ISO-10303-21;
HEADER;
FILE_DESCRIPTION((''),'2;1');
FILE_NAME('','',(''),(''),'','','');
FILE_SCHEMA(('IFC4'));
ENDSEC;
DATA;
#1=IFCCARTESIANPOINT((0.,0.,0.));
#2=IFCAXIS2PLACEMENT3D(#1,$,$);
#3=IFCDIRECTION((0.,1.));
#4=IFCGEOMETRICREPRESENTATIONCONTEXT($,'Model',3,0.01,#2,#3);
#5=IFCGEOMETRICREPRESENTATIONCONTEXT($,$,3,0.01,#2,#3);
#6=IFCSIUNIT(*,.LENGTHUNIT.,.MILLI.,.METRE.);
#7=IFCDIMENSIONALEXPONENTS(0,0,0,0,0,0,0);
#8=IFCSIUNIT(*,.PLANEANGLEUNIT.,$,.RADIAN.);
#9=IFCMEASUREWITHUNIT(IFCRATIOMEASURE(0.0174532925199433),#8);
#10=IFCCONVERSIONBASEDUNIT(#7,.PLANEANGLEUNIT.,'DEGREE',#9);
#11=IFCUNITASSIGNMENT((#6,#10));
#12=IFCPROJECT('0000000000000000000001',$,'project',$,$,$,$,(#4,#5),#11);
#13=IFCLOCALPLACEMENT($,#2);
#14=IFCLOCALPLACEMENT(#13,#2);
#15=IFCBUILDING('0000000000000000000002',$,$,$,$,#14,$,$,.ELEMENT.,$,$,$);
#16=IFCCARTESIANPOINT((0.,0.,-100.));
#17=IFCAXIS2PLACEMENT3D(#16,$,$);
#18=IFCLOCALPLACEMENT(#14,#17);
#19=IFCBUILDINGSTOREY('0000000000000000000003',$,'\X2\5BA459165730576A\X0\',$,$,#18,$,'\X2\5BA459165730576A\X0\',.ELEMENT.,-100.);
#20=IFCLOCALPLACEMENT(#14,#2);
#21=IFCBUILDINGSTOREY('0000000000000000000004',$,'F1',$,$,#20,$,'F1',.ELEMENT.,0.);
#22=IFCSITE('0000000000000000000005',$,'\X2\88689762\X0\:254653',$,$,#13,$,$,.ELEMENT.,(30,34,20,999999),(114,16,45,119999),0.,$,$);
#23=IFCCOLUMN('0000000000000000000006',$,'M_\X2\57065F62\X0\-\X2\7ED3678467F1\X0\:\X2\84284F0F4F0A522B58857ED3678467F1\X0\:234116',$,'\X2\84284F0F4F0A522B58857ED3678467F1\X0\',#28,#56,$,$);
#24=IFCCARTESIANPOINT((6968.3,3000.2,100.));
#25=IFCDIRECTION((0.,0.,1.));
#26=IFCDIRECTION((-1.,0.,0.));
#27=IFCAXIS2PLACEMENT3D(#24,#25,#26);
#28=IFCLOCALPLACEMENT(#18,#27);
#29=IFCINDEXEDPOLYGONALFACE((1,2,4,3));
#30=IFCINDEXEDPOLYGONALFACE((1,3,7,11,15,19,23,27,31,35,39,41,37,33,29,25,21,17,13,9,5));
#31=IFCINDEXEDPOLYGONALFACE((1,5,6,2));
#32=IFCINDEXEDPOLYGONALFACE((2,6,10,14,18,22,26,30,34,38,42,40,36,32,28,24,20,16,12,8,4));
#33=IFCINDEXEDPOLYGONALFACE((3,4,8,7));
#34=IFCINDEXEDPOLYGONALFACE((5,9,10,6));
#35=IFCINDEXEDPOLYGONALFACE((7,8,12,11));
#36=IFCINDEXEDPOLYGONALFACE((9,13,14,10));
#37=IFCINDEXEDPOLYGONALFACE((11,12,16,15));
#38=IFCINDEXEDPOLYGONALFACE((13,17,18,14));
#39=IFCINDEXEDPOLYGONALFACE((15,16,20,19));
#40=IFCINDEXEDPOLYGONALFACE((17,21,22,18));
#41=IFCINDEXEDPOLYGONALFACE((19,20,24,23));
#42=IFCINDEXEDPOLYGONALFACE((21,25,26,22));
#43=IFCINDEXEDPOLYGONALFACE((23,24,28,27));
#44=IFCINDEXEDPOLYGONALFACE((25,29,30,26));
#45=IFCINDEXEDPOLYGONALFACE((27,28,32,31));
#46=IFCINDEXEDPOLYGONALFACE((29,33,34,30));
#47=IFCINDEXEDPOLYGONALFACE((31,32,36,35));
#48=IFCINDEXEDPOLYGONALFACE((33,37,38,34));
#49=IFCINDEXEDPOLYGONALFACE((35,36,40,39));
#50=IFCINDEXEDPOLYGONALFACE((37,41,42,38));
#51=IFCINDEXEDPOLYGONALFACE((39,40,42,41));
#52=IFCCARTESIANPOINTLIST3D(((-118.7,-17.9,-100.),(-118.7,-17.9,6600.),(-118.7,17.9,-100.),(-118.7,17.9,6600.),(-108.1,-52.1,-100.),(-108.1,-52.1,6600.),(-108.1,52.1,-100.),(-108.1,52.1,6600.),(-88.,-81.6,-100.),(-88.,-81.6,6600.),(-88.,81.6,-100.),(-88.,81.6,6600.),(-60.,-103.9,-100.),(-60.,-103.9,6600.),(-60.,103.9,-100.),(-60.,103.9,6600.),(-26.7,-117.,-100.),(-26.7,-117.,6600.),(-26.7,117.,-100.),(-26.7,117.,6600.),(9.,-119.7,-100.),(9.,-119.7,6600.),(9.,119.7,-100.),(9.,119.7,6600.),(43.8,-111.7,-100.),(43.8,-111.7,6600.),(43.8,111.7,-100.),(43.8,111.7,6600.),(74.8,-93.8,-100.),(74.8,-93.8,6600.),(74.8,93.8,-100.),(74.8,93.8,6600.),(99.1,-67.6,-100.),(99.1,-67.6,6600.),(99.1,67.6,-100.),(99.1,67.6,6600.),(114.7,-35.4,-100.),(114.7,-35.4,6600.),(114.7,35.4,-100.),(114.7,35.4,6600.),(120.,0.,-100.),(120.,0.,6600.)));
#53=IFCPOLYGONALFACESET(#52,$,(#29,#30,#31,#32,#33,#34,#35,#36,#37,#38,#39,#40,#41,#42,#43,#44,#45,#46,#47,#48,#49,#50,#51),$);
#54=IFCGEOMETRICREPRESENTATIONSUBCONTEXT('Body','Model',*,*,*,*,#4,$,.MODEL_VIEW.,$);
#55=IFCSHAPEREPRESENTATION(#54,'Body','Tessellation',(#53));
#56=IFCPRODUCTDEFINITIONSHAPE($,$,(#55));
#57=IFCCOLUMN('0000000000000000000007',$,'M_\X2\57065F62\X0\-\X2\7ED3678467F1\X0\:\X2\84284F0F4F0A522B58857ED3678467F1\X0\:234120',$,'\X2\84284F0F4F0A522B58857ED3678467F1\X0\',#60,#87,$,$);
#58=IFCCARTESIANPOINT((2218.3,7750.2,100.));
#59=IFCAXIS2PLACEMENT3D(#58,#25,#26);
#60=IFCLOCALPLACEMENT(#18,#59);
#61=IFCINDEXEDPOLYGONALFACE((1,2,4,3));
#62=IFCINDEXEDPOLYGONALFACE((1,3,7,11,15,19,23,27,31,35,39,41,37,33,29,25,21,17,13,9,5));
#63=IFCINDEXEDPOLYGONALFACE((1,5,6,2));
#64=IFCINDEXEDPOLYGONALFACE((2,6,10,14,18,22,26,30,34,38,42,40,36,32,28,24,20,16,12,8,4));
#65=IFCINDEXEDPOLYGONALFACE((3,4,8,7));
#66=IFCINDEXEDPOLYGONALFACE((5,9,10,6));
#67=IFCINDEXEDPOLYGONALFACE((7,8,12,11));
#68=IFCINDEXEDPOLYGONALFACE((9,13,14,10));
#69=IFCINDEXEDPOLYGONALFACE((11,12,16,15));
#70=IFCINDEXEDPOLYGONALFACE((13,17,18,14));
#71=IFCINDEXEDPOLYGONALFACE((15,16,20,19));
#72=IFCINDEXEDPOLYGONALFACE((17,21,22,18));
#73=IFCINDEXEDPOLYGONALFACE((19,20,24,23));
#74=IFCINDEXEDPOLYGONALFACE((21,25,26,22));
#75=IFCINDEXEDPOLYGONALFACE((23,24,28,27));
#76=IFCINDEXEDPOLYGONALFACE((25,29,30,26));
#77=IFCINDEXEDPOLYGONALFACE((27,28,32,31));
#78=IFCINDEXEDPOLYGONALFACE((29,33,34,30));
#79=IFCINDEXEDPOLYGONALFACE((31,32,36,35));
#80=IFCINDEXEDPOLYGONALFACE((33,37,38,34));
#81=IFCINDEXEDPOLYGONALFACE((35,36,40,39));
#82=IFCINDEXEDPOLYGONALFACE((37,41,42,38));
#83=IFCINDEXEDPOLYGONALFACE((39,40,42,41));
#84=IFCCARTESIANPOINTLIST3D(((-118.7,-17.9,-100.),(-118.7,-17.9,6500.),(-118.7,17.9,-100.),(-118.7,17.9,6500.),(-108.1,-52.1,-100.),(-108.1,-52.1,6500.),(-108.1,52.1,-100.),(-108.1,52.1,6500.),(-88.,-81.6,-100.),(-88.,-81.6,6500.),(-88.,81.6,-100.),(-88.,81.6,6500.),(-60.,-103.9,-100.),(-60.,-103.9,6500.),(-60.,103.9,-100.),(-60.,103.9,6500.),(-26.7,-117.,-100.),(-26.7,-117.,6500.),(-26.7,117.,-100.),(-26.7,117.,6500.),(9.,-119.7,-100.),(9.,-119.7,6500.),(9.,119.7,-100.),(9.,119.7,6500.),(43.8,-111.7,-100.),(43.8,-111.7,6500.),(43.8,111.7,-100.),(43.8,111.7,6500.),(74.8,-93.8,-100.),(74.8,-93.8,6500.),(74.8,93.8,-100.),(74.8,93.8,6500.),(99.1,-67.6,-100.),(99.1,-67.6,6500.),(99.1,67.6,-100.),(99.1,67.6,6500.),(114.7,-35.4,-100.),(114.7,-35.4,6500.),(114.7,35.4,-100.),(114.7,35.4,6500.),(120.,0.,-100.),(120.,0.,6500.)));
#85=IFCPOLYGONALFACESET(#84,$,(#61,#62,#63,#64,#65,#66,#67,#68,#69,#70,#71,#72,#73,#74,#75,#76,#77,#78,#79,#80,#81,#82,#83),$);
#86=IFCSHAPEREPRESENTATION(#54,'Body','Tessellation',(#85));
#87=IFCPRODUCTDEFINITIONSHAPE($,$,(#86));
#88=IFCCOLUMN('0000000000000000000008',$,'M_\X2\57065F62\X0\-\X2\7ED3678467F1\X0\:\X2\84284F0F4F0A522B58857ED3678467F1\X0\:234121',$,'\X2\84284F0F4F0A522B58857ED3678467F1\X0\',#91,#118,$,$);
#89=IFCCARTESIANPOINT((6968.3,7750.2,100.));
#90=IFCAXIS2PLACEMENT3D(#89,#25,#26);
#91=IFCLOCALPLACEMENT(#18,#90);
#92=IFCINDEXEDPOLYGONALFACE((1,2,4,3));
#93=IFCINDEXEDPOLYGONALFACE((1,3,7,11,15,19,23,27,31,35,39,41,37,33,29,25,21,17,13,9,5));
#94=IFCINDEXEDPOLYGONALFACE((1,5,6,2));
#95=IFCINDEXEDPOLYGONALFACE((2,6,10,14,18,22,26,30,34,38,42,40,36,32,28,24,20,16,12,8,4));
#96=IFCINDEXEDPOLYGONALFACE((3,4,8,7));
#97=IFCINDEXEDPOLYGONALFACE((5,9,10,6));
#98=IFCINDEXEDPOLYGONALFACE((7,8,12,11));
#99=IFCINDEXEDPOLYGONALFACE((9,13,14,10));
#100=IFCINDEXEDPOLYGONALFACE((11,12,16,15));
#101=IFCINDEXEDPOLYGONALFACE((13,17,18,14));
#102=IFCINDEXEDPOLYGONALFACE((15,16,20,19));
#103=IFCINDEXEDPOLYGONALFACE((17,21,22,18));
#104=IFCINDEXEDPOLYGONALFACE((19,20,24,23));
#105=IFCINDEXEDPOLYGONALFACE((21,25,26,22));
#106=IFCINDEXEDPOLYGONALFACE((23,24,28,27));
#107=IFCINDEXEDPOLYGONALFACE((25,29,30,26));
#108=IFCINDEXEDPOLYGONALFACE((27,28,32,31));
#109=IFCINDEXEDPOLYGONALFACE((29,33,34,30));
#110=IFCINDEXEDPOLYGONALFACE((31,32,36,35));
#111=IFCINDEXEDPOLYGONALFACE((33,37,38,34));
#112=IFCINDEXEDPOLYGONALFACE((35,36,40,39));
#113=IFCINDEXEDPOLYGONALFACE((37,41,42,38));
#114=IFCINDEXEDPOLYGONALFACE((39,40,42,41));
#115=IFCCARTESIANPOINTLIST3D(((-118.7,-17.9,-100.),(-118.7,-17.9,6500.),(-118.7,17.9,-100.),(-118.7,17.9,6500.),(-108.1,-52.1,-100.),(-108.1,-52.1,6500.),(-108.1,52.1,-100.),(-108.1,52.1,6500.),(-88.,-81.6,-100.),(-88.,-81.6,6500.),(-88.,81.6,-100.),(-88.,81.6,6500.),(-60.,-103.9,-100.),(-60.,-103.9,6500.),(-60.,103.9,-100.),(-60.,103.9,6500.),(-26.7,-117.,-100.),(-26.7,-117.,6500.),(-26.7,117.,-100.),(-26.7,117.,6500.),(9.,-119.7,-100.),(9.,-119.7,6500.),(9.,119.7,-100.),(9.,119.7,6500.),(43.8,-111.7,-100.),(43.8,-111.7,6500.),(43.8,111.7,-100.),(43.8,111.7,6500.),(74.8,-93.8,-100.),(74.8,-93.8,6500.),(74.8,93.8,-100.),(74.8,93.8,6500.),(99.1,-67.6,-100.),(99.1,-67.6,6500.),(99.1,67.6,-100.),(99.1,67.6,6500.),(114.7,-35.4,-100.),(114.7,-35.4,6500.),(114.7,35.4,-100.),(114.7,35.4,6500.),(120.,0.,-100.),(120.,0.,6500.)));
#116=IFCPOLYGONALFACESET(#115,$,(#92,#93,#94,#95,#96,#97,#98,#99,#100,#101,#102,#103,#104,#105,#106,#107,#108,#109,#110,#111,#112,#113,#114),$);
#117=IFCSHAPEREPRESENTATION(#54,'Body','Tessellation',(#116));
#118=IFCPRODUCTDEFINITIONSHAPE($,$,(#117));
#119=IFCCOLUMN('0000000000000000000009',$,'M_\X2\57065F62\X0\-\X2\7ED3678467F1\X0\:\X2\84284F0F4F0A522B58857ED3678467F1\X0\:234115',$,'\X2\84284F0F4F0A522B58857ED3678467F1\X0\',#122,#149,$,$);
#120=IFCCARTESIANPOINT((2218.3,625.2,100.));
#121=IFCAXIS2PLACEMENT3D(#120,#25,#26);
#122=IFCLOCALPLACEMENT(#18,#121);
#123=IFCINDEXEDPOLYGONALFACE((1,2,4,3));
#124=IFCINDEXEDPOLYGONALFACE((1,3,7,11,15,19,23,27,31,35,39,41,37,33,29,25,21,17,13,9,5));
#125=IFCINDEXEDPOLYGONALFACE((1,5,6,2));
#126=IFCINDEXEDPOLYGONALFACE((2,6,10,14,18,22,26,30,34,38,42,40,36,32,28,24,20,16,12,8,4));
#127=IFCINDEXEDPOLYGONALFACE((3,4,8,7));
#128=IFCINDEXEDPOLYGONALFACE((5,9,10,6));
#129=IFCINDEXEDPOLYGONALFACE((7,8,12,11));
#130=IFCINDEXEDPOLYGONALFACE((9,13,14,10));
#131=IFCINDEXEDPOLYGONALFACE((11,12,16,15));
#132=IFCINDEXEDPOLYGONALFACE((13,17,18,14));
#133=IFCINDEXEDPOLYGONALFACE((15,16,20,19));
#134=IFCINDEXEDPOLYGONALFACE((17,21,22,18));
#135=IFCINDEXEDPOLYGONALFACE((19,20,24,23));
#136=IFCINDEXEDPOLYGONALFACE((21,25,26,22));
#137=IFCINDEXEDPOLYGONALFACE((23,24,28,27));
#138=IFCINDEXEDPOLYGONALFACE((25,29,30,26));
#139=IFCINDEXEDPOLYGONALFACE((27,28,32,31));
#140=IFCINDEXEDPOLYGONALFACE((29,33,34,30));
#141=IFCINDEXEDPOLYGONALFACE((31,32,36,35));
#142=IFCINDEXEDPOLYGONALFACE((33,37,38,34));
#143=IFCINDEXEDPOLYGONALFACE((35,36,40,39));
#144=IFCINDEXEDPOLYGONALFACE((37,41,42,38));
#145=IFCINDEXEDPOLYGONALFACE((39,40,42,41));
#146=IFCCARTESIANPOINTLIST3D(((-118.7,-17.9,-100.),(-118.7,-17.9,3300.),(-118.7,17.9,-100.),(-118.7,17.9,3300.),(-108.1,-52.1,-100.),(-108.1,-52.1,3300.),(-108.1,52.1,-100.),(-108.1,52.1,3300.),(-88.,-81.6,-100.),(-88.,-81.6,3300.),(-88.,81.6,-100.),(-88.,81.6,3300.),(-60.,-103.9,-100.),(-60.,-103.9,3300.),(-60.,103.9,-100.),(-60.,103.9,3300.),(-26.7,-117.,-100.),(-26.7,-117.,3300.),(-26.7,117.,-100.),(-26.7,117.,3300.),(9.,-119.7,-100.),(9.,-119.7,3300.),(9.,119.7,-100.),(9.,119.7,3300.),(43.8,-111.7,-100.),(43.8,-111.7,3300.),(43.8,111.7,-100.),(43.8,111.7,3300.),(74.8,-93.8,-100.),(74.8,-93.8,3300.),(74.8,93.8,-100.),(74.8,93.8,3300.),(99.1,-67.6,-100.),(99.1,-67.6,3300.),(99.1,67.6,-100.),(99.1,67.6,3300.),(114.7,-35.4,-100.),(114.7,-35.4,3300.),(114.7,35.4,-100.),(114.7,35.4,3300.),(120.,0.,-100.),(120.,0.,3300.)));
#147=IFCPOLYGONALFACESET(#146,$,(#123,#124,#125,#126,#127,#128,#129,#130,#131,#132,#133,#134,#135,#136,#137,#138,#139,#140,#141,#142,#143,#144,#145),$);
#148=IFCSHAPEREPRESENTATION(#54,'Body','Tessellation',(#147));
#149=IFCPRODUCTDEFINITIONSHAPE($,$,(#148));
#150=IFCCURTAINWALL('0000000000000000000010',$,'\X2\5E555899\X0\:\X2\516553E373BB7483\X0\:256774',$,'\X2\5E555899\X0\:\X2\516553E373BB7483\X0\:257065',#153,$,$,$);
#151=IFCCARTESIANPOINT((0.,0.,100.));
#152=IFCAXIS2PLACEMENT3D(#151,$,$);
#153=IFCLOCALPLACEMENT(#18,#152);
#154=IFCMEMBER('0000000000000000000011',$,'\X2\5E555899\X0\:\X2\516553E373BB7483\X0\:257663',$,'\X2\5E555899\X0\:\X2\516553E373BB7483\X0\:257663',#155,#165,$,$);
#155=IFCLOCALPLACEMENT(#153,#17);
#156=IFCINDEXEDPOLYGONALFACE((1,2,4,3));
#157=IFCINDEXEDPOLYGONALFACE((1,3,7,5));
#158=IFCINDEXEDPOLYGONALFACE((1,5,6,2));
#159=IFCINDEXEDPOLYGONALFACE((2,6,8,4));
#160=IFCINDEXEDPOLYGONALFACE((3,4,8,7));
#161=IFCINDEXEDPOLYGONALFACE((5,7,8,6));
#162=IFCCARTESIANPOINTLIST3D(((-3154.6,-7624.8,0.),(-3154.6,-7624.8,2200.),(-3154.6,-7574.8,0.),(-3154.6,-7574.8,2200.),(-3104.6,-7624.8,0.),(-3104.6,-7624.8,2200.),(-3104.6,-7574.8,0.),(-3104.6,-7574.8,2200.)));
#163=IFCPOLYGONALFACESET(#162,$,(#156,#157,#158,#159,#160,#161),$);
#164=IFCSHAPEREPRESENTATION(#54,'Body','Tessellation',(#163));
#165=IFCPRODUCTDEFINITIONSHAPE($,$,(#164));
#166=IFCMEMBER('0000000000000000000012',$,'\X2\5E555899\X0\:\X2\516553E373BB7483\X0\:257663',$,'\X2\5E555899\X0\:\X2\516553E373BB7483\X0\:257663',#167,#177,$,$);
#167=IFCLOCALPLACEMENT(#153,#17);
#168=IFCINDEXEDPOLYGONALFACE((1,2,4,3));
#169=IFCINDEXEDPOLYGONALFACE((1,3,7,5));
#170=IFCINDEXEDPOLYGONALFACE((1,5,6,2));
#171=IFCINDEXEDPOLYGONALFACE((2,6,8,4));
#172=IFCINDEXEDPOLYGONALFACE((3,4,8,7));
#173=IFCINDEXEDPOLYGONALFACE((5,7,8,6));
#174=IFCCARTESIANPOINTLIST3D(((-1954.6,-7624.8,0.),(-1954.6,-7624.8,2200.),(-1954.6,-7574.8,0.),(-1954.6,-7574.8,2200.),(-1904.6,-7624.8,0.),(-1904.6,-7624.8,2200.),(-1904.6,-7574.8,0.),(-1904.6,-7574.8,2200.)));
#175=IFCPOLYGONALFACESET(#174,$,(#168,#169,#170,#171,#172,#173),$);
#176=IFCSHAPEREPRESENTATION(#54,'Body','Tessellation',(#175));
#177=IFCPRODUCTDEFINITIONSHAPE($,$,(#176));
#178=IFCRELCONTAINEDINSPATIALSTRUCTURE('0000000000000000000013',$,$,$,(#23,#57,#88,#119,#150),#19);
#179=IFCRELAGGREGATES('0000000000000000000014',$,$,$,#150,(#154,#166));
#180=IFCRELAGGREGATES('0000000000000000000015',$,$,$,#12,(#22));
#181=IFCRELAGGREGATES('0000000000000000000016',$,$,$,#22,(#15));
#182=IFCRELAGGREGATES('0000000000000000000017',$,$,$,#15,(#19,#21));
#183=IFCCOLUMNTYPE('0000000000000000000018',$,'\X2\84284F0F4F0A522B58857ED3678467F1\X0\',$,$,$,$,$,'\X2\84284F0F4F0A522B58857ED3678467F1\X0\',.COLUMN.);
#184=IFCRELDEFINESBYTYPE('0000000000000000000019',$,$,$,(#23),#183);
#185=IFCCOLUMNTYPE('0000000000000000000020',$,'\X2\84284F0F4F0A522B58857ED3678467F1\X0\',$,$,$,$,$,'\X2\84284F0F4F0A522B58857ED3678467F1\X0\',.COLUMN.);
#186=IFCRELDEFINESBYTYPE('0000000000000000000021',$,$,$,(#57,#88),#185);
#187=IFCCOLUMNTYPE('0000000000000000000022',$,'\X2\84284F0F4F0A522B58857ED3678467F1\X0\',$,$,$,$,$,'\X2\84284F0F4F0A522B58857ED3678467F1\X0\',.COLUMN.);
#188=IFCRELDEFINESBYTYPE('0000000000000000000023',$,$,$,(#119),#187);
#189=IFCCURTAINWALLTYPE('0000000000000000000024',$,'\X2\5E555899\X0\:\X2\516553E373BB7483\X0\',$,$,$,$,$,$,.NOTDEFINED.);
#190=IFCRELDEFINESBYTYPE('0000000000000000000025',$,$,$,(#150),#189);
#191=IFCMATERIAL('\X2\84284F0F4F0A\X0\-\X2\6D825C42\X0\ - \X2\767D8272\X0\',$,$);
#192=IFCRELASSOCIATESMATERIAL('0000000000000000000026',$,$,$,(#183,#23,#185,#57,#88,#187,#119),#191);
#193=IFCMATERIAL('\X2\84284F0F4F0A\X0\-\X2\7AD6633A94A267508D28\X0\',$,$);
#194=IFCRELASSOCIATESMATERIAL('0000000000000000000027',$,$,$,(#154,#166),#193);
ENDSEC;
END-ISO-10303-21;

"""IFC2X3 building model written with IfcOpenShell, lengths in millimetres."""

from ifc_helpers import new_model, entity, si_unit, converted_unit, direction, frame, frame_2d, origin, place, context, subcontext, project, spatial, rectangle, circle, extrude, source, transform, mapped, material, type_object, type_shapes, element, aggregate, save


model = new_model("IFC2X3")

# Units and contexts
model_context = context("Model", 3, precision=0.01, world=origin(), true_north=direction((0.0, 1.0)))
context_of_model = context(None, 3, precision=0.01, world=origin(), true_north=direction((0.0, 1.0)))
body_context = subcontext(model_context, "Body", "Model", "MODEL_VIEW")
ifc_project = project(units=[si_unit("LENGTHUNIT", "METRE", prefix="MILLI"), converted_unit("PLANEANGLEUNIT", "DEGREE", entity("IfcRatioMeasure", 0.0174532925199433), si_unit("PLANEANGLEUNIT", "RADIAN"), dimensions=[0, 0, 0, 0, 0, 0, 0])], contexts=[model_context, context_of_model])

# Site, building, storey
site_placement = place(None, origin())
site = spatial("IfcSite", under=ifc_project, at=site_placement, Name="表面:254653", CompositionType="ELEMENT", RefLatitude=(30, 34, 20, 999999), RefLongitude=(114, 16, 45, 119999), RefElevation=0.0)
building_placement = place(site_placement, origin())
building = spatial("IfcBuilding", under=site, at=building_placement, CompositionType="ELEMENT")
storey_1_placement = place(building_placement, frame((0.0, 0.0, -100.0)))
storey_1 = spatial("IfcBuildingStorey", under=building, at=storey_1_placement, Name="室外地坪", LongName="室外地坪", CompositionType="ELEMENT", Elevation=-100.0)

# Columns
ifc_material_1 = material(Name="萨伏伊-涂层 - 白色")
column_type_1 = type_object("IfcColumnType", Name="萨伏伊别墅结构柱", ElementType="萨伏伊别墅结构柱", PredefinedType="COLUMN", material=ifc_material_1)
shared_shape_1 = source(origin(), body_context, "Body", "SweptSolid", [
    extrude(circle(Radius=120.0, at=frame_2d((0.0, 0.0), x_axis=(1.0, 0.0))), frame((0.0, 0.0, -100.0)), (0.0, 0.0, 1.0), 6700.0),
])
type_shapes(column_type_1, [shared_shape_1])
column_1_placement = place(storey_1_placement, frame((6968.3, 3000.2, 100.0), z_axis=(0.0, 0.0, 1.0), x_axis=(-1.0, 0.0, 0.0)))
element("IfcColumn", 1, at=column_1_placement, inside=storey_1, type_object=column_type_1, material=ifc_material_1, Name="M_圆形-结构柱:萨伏伊别墅结构柱:234116", ObjectType="萨伏伊别墅结构柱", context=body_context, shape_type="MappedRepresentation", body=[
    mapped(shared_shape_1, transform((0.0, 0.0, 0.0), scale=1.0)),
])
column_type_2 = type_object("IfcColumnType", Name="萨伏伊别墅结构柱", ElementType="萨伏伊别墅结构柱", PredefinedType="COLUMN", material=ifc_material_1)
shared_shape_2 = source(origin(), body_context, "Body", "SweptSolid", [
    extrude(circle(Radius=120.0, at=frame_2d((0.0, 0.0), x_axis=(1.0, 0.0))), frame((0.0, 0.0, -100.0)), (0.0, 0.0, 1.0), 6600.0),
])
type_shapes(column_type_2, [shared_shape_2])
for number, where, z_axis, x_axis, name in (
    (2, (2218.3, 7750.2, 100.0), (0.0, 0.0, 1.0), (-1.0, 0.0, 0.0), "M_圆形-结构柱:萨伏伊别墅结构柱:234120"),
    (3, (6968.3, 7750.2, 100.0), (0.0, 0.0, 1.0), (-1.0, 0.0, 0.0), "M_圆形-结构柱:萨伏伊别墅结构柱:234121"),
):
    element("IfcColumn", number, at=place(storey_1_placement, frame(where, z_axis=z_axis, x_axis=x_axis)), inside=storey_1, type_object=column_type_2, material=ifc_material_1, Name=name, ObjectType="萨伏伊别墅结构柱", context=body_context, shape_type="MappedRepresentation", body=[
        mapped(shared_shape_2, transform((0.0, 0.0, 0.0), scale=1.0)),
    ])
column_type_3 = type_object("IfcColumnType", Name="萨伏伊别墅结构柱", ElementType="萨伏伊别墅结构柱", PredefinedType="COLUMN", material=ifc_material_1)
shared_shape_3 = source(origin(), body_context, "Body", "SweptSolid", [
    extrude(circle(Radius=120.0, at=frame_2d((0.0, 0.0), x_axis=(1.0, 0.0))), frame((0.0, 0.0, -100.0)), (0.0, 0.0, 1.0), 3400.0),
])
type_shapes(column_type_3, [shared_shape_3])
column_2_placement = place(storey_1_placement, frame((2218.3, 625.2, 100.0), z_axis=(0.0, 0.0, 1.0), x_axis=(-1.0, 0.0, 0.0)))
element("IfcColumn", 4, at=column_2_placement, inside=storey_1, type_object=column_type_3, material=ifc_material_1, Name="M_圆形-结构柱:萨伏伊别墅结构柱:234115", ObjectType="萨伏伊别墅结构柱", context=body_context, shape_type="MappedRepresentation", body=[
    mapped(shared_shape_3, transform((0.0, 0.0, 0.0), scale=1.0)),
])

# Curtain wall, members
ifc_material_2 = material(Name="萨伏伊-竖挺钢材质")
curtain_wall_type_1 = type_object("IfcCurtainWallType", Name="幕墙:入口玻璃", PredefinedType="NOTDEFINED")
curtain_wall_1_placement = place(storey_1_placement, frame((0.0, 0.0, 100.0)))
curtain_wall_1 = element("IfcCurtainWall", 5, at=curtain_wall_1_placement, inside=storey_1, type_object=curtain_wall_type_1, Name="幕墙:入口玻璃:256774", ObjectType="幕墙:入口玻璃:257065")
member_1_placement = place(curtain_wall_1_placement, frame((0.0, 0.0, -100.0)))
member_1 = element("IfcMember", 6, at=member_1_placement, material=ifc_material_2, Name="幕墙:入口玻璃:257663", ObjectType="幕墙:入口玻璃:257663", context=body_context, shape_type="SweptSolid", body=[
    extrude(rectangle(XDim=50.0, YDim=50.0, at=frame_2d((0.0, 0.0), x_axis=(1.0, 0.0))), frame((-3129.6, -7599.8, 0.0), z_axis=(0.0, 0.0, 1.0), x_axis=(-1.0, 0.0, 0.0)), (0.0, 0.0, 1.0), 2200.0),
])
member_2_placement = place(curtain_wall_1_placement, frame((0.0, 0.0, -100.0)))
member_2 = element("IfcMember", 7, at=member_2_placement, material=ifc_material_2, Name="幕墙:入口玻璃:257663", ObjectType="幕墙:入口玻璃:257663", context=body_context, shape_type="SweptSolid", body=[
    extrude(rectangle(XDim=50.0, YDim=50.0, at=frame_2d((0.0, 0.0), x_axis=(1.0, 0.0))), frame((-1929.6, -7599.8, 0.0), z_axis=(0.0, 0.0, 1.0), x_axis=(-1.0, 0.0, 0.0)), (0.0, 0.0, 1.0), 2200.0),
])
aggregate(curtain_wall_1, [member_1, member_2])

# Shared definitions
storey_2_placement = place(building_placement, origin())
storey_2 = spatial("IfcBuildingStorey", under=building, at=storey_2_placement, Name="F1", LongName="F1", CompositionType="ELEMENT", Elevation=0.0)

save(model, "model.ifc")
